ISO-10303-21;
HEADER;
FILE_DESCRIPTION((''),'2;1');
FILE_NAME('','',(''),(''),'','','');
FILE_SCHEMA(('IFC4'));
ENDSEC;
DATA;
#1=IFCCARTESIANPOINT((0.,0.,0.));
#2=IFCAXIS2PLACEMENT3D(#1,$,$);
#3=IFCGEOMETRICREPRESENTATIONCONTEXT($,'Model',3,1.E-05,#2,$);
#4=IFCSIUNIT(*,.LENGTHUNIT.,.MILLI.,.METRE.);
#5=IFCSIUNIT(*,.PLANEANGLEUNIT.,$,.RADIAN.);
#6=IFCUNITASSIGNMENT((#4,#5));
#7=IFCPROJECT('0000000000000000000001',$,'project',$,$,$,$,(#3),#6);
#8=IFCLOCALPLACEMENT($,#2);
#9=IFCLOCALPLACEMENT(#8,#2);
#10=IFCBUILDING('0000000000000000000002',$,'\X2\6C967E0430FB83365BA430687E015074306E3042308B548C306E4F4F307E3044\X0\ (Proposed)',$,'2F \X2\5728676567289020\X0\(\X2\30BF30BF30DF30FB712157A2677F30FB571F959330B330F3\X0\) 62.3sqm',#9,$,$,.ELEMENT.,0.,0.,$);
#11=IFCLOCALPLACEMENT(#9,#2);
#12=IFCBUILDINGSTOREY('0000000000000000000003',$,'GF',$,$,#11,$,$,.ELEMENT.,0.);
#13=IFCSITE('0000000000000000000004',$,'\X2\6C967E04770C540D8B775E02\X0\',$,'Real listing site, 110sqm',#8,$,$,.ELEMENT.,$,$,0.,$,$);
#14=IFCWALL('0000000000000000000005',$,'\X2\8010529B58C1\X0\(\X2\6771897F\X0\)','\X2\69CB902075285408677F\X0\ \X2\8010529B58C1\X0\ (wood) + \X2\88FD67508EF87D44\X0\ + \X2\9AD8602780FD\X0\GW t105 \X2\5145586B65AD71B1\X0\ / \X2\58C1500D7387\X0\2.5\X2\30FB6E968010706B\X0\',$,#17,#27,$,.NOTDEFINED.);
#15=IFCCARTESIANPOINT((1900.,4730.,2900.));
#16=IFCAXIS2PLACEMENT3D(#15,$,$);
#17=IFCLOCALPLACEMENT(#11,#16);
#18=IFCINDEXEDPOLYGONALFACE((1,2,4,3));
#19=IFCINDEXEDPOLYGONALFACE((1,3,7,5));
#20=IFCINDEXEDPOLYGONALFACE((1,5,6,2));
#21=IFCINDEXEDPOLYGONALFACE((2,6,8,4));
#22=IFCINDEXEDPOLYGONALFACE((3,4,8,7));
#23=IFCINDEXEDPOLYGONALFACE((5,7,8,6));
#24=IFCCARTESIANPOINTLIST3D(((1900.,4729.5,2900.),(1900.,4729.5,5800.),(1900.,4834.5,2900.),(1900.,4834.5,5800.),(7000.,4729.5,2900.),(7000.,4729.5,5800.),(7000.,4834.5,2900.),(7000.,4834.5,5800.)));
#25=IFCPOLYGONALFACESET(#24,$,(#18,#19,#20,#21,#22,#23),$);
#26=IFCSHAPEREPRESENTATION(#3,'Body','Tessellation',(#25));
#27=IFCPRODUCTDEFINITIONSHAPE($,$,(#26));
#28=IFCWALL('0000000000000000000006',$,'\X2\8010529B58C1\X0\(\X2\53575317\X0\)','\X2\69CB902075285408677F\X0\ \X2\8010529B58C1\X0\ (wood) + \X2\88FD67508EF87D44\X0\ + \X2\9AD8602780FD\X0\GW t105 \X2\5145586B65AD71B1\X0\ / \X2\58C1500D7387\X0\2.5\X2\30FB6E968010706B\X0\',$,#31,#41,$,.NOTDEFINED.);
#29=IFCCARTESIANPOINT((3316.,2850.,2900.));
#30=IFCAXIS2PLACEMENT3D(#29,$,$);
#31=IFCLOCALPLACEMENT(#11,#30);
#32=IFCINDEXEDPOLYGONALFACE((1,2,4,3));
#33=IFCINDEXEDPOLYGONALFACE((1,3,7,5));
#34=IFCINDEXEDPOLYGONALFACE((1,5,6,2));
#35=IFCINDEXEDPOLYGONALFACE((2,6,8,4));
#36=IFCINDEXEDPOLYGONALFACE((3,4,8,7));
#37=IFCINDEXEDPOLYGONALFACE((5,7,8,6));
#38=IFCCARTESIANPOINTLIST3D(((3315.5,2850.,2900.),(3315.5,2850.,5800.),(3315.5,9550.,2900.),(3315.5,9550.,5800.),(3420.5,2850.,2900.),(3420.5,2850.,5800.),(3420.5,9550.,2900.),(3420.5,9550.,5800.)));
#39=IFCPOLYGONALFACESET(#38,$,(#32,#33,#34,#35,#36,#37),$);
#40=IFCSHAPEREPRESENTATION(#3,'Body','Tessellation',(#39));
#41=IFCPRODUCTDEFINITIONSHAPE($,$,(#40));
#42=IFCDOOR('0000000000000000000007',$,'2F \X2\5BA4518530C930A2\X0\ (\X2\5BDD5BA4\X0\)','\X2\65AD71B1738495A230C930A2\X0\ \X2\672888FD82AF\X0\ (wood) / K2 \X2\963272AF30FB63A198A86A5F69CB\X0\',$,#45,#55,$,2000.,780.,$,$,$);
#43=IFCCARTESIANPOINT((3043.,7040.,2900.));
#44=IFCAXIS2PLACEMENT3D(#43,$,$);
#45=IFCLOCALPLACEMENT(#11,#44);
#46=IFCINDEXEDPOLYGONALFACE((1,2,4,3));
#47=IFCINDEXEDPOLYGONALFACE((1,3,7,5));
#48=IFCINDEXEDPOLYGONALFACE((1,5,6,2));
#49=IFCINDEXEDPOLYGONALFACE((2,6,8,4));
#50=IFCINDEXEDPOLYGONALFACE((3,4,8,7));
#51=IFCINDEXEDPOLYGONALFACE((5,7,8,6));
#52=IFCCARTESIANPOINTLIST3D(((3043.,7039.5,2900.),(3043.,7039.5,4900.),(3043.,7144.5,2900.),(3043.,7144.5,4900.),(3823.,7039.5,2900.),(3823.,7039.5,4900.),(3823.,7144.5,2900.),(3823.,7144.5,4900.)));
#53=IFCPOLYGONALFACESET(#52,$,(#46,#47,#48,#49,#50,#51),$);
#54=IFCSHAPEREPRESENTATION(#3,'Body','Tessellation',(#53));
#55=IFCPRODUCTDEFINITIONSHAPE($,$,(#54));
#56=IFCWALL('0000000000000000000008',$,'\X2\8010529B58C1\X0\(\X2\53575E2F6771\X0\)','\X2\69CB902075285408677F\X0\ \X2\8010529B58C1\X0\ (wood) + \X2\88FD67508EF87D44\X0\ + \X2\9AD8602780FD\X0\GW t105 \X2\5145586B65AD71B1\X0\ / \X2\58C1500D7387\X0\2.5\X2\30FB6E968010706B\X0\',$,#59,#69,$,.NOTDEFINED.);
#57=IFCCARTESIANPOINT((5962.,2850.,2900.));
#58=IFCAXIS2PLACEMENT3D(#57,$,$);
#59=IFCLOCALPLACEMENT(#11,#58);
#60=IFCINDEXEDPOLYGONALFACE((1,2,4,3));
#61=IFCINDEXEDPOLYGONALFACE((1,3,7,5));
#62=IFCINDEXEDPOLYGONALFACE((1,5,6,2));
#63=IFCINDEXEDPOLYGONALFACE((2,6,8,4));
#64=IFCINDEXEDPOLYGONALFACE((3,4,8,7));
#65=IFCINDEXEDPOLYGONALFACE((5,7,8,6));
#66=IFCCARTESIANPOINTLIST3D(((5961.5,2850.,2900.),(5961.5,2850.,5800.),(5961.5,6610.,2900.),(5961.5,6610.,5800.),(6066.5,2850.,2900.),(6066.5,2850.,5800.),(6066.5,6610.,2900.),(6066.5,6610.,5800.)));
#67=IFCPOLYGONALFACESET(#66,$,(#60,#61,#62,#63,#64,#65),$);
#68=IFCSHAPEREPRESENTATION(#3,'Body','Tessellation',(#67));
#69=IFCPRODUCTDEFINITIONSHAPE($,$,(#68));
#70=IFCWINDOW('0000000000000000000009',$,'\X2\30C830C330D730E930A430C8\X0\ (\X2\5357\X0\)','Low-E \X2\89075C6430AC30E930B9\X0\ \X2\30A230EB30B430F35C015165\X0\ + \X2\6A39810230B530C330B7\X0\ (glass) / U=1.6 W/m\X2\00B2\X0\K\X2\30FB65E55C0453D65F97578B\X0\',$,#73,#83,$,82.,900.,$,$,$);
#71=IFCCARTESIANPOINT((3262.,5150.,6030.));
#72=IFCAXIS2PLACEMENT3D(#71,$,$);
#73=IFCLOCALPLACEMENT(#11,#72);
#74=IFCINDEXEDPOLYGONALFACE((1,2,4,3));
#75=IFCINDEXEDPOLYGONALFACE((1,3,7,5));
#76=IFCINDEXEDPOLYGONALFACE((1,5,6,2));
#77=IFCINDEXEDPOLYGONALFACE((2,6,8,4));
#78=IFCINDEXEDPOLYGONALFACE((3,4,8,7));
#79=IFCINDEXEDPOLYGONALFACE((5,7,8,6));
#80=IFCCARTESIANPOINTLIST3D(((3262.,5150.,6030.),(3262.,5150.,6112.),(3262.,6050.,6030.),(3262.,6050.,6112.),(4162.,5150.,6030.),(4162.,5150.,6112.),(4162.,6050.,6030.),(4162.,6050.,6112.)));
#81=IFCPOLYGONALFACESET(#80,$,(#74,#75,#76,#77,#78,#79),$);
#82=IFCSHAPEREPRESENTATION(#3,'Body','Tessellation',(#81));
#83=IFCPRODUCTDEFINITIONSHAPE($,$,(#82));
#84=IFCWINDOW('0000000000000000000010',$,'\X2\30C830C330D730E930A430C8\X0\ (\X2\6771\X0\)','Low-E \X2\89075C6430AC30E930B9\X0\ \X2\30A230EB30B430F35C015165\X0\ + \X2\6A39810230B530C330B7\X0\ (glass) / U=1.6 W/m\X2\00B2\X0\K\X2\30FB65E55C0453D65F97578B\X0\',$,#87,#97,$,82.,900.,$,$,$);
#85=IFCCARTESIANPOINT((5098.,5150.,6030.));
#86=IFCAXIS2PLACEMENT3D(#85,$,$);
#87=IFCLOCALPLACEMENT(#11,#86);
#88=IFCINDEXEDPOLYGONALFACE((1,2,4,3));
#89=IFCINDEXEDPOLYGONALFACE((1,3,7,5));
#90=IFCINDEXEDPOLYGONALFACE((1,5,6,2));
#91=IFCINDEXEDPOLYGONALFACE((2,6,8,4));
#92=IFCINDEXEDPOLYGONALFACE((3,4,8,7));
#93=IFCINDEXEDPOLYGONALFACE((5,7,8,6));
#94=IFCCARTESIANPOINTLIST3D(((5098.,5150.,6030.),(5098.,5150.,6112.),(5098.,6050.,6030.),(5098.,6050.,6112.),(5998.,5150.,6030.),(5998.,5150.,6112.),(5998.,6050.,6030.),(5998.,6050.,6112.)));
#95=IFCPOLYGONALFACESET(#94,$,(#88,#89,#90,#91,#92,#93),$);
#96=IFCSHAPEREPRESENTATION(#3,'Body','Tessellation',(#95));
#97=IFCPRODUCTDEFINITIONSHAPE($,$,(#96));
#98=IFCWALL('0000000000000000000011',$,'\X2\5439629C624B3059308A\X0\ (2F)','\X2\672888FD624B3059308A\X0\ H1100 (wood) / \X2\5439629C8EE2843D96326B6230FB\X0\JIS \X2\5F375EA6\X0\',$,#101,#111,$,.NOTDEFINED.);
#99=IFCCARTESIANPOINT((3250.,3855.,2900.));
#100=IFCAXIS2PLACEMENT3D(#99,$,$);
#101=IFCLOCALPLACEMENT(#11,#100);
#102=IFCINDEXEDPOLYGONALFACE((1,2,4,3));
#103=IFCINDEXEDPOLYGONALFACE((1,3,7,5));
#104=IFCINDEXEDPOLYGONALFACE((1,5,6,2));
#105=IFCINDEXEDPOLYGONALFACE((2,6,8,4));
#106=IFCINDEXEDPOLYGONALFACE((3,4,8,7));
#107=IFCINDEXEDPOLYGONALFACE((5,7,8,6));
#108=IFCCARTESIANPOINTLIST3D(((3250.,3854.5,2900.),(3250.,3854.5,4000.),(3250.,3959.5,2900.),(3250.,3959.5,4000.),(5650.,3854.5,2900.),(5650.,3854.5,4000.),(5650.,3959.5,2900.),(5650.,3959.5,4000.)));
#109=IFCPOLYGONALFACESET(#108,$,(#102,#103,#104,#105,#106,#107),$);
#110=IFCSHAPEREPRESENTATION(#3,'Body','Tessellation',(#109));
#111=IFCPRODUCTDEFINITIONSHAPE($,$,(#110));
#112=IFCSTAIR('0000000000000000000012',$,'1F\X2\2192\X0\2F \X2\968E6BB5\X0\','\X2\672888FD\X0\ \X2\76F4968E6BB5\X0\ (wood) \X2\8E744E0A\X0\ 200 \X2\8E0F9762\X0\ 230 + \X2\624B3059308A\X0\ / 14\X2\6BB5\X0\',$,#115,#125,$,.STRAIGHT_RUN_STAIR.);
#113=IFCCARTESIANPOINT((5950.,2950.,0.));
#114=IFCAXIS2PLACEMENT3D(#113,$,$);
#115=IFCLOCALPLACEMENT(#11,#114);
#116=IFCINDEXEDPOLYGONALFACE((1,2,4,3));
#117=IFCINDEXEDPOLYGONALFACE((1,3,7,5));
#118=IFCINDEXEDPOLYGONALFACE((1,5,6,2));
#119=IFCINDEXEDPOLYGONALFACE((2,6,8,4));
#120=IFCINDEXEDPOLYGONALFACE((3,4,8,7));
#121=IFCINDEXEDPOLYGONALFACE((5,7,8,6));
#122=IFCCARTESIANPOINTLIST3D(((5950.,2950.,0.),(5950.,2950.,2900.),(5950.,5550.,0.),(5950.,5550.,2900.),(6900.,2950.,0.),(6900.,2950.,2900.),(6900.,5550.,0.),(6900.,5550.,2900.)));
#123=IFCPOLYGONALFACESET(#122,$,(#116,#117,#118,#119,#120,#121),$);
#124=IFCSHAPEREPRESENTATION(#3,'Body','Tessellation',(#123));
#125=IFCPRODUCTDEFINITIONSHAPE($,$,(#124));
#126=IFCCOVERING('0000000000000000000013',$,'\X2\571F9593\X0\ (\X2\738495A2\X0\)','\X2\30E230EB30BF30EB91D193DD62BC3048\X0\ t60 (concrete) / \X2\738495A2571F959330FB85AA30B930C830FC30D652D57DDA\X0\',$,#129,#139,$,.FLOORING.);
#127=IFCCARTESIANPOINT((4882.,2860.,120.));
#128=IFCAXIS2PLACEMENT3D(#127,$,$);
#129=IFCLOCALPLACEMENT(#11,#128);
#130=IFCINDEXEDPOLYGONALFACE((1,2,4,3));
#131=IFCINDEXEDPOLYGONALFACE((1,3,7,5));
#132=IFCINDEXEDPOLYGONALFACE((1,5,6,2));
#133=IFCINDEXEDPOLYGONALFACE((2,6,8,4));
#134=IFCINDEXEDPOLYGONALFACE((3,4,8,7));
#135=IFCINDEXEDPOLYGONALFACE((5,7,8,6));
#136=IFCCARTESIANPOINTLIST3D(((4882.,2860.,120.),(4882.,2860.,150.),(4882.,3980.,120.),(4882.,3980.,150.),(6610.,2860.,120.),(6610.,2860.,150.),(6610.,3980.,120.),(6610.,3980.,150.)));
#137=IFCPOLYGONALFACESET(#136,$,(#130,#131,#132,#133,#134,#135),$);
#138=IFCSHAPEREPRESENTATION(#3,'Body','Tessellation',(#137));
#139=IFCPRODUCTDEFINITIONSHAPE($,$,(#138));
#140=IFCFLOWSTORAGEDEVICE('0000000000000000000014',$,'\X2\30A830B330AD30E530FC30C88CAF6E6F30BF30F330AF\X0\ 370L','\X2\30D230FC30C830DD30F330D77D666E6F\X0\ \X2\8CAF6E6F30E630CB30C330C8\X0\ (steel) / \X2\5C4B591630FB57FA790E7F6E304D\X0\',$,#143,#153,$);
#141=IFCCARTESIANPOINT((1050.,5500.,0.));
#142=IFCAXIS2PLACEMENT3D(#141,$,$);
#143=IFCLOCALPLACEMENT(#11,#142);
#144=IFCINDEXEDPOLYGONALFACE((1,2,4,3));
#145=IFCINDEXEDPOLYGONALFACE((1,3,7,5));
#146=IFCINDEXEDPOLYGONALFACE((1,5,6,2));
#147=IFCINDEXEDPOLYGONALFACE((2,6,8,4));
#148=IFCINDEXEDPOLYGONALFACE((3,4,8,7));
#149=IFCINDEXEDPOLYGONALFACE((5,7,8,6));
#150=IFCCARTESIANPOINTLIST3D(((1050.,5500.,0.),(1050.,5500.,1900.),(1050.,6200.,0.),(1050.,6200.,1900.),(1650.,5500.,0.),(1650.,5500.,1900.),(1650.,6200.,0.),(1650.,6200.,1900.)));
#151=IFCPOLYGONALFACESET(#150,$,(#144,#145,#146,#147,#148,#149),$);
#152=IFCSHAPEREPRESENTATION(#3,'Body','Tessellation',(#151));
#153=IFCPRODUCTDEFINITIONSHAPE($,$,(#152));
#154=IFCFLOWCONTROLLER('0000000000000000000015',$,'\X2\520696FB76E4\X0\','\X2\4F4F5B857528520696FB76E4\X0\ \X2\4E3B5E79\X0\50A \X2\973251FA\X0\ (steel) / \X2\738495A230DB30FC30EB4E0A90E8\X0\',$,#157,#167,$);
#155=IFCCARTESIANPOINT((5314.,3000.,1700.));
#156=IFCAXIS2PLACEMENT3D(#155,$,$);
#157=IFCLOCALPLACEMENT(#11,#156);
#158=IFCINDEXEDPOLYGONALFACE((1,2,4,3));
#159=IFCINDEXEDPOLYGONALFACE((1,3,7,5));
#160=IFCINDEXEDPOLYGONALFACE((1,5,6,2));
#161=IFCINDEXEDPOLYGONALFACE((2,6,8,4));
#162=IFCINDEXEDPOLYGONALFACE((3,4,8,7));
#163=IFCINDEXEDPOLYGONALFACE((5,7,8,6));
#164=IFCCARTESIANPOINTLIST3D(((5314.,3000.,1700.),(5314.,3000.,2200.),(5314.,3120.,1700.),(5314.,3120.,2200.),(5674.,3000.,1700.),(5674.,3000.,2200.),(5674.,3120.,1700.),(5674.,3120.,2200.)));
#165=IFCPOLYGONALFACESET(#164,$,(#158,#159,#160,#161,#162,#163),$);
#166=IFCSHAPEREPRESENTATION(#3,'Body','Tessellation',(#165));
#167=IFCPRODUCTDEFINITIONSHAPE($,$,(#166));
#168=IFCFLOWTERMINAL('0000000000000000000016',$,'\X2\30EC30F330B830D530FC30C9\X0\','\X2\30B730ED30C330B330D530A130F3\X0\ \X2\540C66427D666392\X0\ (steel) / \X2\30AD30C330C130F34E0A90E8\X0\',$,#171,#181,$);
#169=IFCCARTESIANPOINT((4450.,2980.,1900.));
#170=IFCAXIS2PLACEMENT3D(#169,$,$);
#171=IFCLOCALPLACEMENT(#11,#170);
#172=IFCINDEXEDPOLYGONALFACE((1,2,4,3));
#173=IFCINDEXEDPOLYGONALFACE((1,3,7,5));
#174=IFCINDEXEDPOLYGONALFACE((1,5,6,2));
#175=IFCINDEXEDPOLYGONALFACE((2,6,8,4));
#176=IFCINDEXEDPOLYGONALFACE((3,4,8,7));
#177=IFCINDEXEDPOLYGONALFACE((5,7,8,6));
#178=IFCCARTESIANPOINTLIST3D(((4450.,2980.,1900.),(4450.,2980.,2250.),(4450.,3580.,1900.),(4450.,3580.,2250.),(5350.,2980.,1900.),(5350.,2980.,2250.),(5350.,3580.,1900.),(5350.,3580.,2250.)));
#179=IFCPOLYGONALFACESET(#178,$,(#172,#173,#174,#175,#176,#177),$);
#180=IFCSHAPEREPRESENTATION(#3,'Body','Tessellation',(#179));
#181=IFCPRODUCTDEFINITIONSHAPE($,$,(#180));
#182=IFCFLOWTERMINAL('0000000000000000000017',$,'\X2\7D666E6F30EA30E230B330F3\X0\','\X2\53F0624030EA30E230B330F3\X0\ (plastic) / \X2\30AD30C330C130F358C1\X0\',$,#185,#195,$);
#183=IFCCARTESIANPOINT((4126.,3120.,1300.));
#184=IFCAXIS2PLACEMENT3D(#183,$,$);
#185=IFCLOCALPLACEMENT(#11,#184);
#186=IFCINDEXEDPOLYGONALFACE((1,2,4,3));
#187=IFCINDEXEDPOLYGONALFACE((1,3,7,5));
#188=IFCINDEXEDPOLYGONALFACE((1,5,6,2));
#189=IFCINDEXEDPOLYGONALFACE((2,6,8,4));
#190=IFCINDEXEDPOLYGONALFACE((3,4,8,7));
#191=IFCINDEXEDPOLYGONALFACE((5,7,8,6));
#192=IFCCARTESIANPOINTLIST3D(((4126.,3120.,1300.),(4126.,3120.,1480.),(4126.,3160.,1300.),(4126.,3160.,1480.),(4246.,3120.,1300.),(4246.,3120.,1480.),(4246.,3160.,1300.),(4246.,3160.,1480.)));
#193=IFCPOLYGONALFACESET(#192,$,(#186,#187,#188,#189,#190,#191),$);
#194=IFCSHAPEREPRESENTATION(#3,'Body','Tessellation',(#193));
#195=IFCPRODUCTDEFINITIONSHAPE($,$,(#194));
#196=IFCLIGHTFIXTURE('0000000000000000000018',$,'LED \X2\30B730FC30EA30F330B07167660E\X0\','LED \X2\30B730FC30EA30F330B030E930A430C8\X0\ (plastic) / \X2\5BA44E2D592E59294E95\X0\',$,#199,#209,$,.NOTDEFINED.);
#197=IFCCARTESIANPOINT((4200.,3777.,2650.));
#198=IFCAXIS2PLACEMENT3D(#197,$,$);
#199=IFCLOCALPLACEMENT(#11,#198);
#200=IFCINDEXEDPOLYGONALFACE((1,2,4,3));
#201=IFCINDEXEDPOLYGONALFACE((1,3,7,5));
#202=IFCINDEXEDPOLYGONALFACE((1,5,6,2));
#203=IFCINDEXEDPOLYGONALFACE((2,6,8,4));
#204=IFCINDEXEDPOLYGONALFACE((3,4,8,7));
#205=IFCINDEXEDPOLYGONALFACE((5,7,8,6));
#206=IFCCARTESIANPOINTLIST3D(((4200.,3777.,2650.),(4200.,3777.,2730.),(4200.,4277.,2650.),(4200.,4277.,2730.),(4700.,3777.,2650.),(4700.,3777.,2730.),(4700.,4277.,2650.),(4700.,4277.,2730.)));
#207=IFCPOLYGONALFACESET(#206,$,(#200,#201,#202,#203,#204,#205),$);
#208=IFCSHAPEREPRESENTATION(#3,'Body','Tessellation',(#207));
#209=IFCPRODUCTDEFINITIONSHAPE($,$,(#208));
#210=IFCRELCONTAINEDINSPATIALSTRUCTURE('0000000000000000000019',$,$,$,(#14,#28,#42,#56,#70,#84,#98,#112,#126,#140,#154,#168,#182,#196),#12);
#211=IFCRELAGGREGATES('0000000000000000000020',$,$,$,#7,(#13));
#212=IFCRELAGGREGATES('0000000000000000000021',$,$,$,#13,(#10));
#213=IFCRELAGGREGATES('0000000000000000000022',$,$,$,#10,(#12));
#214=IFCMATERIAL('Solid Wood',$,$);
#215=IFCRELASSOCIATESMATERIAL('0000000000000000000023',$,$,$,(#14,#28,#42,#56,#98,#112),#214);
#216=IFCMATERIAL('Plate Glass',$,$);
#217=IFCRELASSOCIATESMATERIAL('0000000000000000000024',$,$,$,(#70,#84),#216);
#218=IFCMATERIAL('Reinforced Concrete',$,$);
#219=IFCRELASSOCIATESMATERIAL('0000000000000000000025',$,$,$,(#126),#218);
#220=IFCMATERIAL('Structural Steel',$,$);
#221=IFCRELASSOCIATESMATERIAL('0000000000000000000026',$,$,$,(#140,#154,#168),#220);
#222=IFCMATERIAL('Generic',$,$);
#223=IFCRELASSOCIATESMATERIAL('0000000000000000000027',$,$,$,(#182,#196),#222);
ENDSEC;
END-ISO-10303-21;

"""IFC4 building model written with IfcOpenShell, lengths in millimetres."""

from ifc_helpers import new_model, si_unit, frame, frame_2d, origin, place, context, project, spatial, rectangle, extrude, material, element, fill, save


model = new_model("IFC4")

# Units and contexts
model_context = context("Model", 3, precision=1e-05, world=origin())
ifc_project = project(units=[si_unit("LENGTHUNIT", "METRE", prefix="MILLI"), si_unit("PLANEANGLEUNIT", "RADIAN")], contexts=[model_context])

# Site, building, storey
site_placement = place(None, origin())
site = spatial("IfcSite", under=ifc_project, at=site_placement, Name="沖縄県名護市", ObjectType="Real listing site, 110sqm", CompositionType="ELEMENT", RefElevation=0.0)
building_placement = place(site_placement, origin())
building = spatial("IfcBuilding", under=site, at=building_placement, Name="沖縄・茶室と縁側のある和の住まい (Proposed)", ObjectType="2F 在来木造(タタミ・無垢板・土間コン) 62.3sqm", CompositionType="ELEMENT", ElevationOfRefHeight=0.0, ElevationOfTerrain=0.0)
storey_placement = place(building_placement, origin())
storey = spatial("IfcBuildingStorey", under=building, at=storey_placement, Name="GF", CompositionType="ELEMENT", Elevation=0.0)

# Shared definitions
ifc_material_1 = material(Name="Solid Wood")

# Wall
wall_1_placement = place(storey_placement, frame((1900.0, 4730.0, 2900.0)))
element("IfcWall", 1, at=wall_1_placement, inside=storey, material=ifc_material_1, Name="耐力壁(東西)", Description="構造用合板 耐力壁 (wood) + 製材軸組 + 高性能GW t105 充填断熱 / 壁倍率2.5・準耐火", PredefinedType="NOTDEFINED", context=model_context, shape_type="SweptSolid", body=[
    extrude(rectangle(XDim=5100.0, YDim=105.0, at=frame_2d((2550.0, 52.0))), frame((1900.0, 4730.0, 2900.0)), (0.0, 0.0, 1.0), 2900.0),
])

# Wall, opening, door
wall_2_placement = place(storey_placement, frame((3316.0, 2850.0, 2900.0)))
wall_2 = element("IfcWall", 2, at=wall_2_placement, inside=storey, material=ifc_material_1, Name="耐力壁(南北)", Description="構造用合板 耐力壁 (wood) + 製材軸組 + 高性能GW t105 充填断熱 / 壁倍率2.5・準耐火", PredefinedType="NOTDEFINED", context=model_context, shape_type="SweptSolid", body=[
    extrude(rectangle(XDim=105.0, YDim=6700.0, at=frame_2d((52.0, 3350.0))), frame((3316.0, 2850.0, 2900.0)), (0.0, 0.0, 1.0), 2900.0),
])
opening_placement = place(storey_placement, frame((3043.0, 7040.0, 2900.0)))
opening = element("IfcOpeningElement", 3, at=opening_placement, cuts=wall_2, PredefinedType="NOTDEFINED", context=model_context, shape_type="SweptSolid", body=[
    extrude(rectangle(XDim=780.0, YDim=105.0, at=frame_2d((390.0, 52.0))), frame((3043.0, 7040.0, 2900.0)), (0.0, 0.0, 1.0), 2000.0),
])
door_placement = place(storey_placement, frame((3043.0, 7040.0, 2900.0)))
door = element("IfcDoor", 4, at=door_placement, inside=storey, material=ifc_material_1, Name="2F 室内ドア (寝室)", Description="断熱玄関ドア 木製芯 (wood) / K2 防犯・採風機構", OverallHeight=2000.0, OverallWidth=780.0, context=model_context, shape_type="SweptSolid", body=[
    extrude(rectangle(XDim=780.0, YDim=105.0, at=frame_2d((390.0, 52.0))), frame((3043.0, 7040.0, 2900.0)), (0.0, 0.0, 1.0), 2000.0),
])
fill(opening, door)

# Wall
wall_3_placement = place(storey_placement, frame((5962.0, 2850.0, 2900.0)))
element("IfcWall", 5, at=wall_3_placement, inside=storey, material=ifc_material_1, Name="耐力壁(南帯東)", Description="構造用合板 耐力壁 (wood) + 製材軸組 + 高性能GW t105 充填断熱 / 壁倍率2.5・準耐火", PredefinedType="NOTDEFINED", context=model_context, shape_type="SweptSolid", body=[
    extrude(rectangle(XDim=105.0, YDim=3760.0, at=frame_2d((52.0, 1880.0))), frame((5962.0, 2850.0, 2900.0)), (0.0, 0.0, 1.0), 2900.0),
])

# Windows
ifc_material_2 = material(Name="Plate Glass")
window_1_placement = place(storey_placement, frame((3262.0, 5150.0, 6030.0)))
element("IfcWindow", 6, at=window_1_placement, inside=storey, material=ifc_material_2, Name="トップライト (南)", Description="Low-E 複層ガラス アルゴン封入 + 樹脂サッシ (glass) / U=1.6 W/m²K・日射取得型", OverallHeight=82.0, OverallWidth=900.0, context=model_context, shape_type="SweptSolid", body=[
    extrude(rectangle(XDim=900.0, YDim=900.0, at=frame_2d((450.0, 450.0))), frame((3262.0, 5150.0, 6030.0)), (0.0, 0.0, 1.0), 82.0),
])
window_2_placement = place(storey_placement, frame((5098.0, 5150.0, 6030.0)))
element("IfcWindow", 7, at=window_2_placement, inside=storey, material=ifc_material_2, Name="トップライト (東)", Description="Low-E 複層ガラス アルゴン封入 + 樹脂サッシ (glass) / U=1.6 W/m²K・日射取得型", OverallHeight=82.0, OverallWidth=900.0, context=model_context, shape_type="SweptSolid", body=[
    extrude(rectangle(XDim=900.0, YDim=900.0, at=frame_2d((450.0, 450.0))), frame((5098.0, 5150.0, 6030.0)), (0.0, 0.0, 1.0), 82.0),
])

# Wall
wall_4_placement = place(storey_placement, frame((3250.0, 3855.0, 2900.0)))
element("IfcWall", 8, at=wall_4_placement, inside=storey, material=ifc_material_1, Name="吹抜手すり (2F)", Description="木製手すり H1100 (wood) / 吹抜転落防止・JIS 強度", PredefinedType="NOTDEFINED", context=model_context, shape_type="SweptSolid", body=[
    extrude(rectangle(XDim=2400.0, YDim=105.0, at=frame_2d((1200.0, 52.0))), frame((3250.0, 3855.0, 2900.0)), (0.0, 0.0, 1.0), 1100.0),
])

# Stair
stair_placement = place(storey_placement, frame((5950.0, 2950.0, 0.0)))
element("IfcStair", 9, at=stair_placement, inside=storey, material=ifc_material_1, Name="1F→2F 階段", Description="木製 直階段 (wood) 蹴上 200 踏面 230 + 手すり / 14段", PredefinedType="STRAIGHT_RUN_STAIR", context=model_context, shape_type="SweptSolid", body=[
    extrude(rectangle(XDim=950.0, YDim=2600.0, at=frame_2d((475.0, 1300.0))), frame((5950.0, 2950.0, 0.0)), (0.0, 0.0, 1.0), 2900.0),
])

# Covering
ifc_material_3 = material(Name="Reinforced Concrete")
covering_placement = place(storey_placement, frame((4882.0, 2860.0, 120.0)))
element("IfcCovering", 10, at=covering_placement, inside=storey, material=ifc_material_3, Name="土間 (玄関)", Description="モルタル金鏝押え t60 (concrete) / 玄関土間・薪ストーブ動線", PredefinedType="FLOORING", context=model_context, shape_type="SweptSolid", body=[
    extrude(rectangle(XDim=1728.0, YDim=1120.0, at=frame_2d((864.0, 560.0))), frame((4882.0, 2860.0, 120.0)), (0.0, 0.0, 1.0), 30.0),
])

# Flow storage device
ifc_material_4 = material(Name="Structural Steel")
flow_storage_device_placement = place(storey_placement, frame((1050.0, 5500.0, 0.0)))
element("IfcFlowStorageDevice", 11, at=flow_storage_device_placement, inside=storey, material=ifc_material_4, Name="エコキュート貯湯タンク 370L", Description="ヒートポンプ給湯 貯湯ユニット (steel) / 屋外・基礎置き", context=model_context, shape_type="SweptSolid", body=[
    extrude(rectangle(XDim=600.0, YDim=700.0, at=frame_2d((300.0, 350.0))), frame((1050.0, 5500.0, 0.0)), (0.0, 0.0, 1.0), 1900.0),
])

# Flow controller
flow_controller_placement = place(storey_placement, frame((5314.0, 3000.0, 1700.0)))
element("IfcFlowController", 12, at=flow_controller_placement, inside=storey, material=ifc_material_4, Name="分電盤", Description="住宅用分電盤 主幹50A 露出 (steel) / 玄関ホール上部", context=model_context, shape_type="SweptSolid", body=[
    extrude(rectangle(XDim=360.0, YDim=120.0, at=frame_2d((180.0, 60.0))), frame((5314.0, 3000.0, 1700.0)), (0.0, 0.0, 1.0), 500.0),
])

# Flow terminals
flow_terminal_1_placement = place(storey_placement, frame((4450.0, 2980.0, 1900.0)))
element("IfcFlowTerminal", 13, at=flow_terminal_1_placement, inside=storey, material=ifc_material_4, Name="レンジフード", Description="シロッコファン 同時給排 (steel) / キッチン上部", context=model_context, shape_type="SweptSolid", body=[
    extrude(rectangle(XDim=900.0, YDim=600.0, at=frame_2d((450.0, 300.0))), frame((4450.0, 2980.0, 1900.0)), (0.0, 0.0, 1.0), 350.0),
])
ifc_material_5 = material(Name="Generic")
flow_terminal_2_placement = place(storey_placement, frame((4126.0, 3120.0, 1300.0)))
element("IfcFlowTerminal", 14, at=flow_terminal_2_placement, inside=storey, material=ifc_material_5, Name="給湯リモコン", Description="台所リモコン (plastic) / キッチン壁", context=model_context, shape_type="SweptSolid", body=[
    extrude(rectangle(XDim=120.0, YDim=40.0, at=frame_2d((60.0, 20.0))), frame((4126.0, 3120.0, 1300.0)), (0.0, 0.0, 1.0), 180.0),
])

# Light fixture
light_fixture_1_placement = place(storey_placement, frame((4200.0, 3777.0, 2650.0)))
element("IfcLightFixture", 15, at=light_fixture_1_placement, inside=storey, material=ifc_material_5, Name="LED シーリング照明", Description="LED シーリングライト (plastic) / 室中央天井", PredefinedType="NOTDEFINED", context=model_context, shape_type="SweptSolid", body=[
    extrude(rectangle(XDim=500.0, YDim=500.0, at=frame_2d((250.0, 250.0))), frame((4200.0, 3777.0, 2650.0)), (0.0, 0.0, 1.0), 80.0),
])

save(model, "model.ifc")
